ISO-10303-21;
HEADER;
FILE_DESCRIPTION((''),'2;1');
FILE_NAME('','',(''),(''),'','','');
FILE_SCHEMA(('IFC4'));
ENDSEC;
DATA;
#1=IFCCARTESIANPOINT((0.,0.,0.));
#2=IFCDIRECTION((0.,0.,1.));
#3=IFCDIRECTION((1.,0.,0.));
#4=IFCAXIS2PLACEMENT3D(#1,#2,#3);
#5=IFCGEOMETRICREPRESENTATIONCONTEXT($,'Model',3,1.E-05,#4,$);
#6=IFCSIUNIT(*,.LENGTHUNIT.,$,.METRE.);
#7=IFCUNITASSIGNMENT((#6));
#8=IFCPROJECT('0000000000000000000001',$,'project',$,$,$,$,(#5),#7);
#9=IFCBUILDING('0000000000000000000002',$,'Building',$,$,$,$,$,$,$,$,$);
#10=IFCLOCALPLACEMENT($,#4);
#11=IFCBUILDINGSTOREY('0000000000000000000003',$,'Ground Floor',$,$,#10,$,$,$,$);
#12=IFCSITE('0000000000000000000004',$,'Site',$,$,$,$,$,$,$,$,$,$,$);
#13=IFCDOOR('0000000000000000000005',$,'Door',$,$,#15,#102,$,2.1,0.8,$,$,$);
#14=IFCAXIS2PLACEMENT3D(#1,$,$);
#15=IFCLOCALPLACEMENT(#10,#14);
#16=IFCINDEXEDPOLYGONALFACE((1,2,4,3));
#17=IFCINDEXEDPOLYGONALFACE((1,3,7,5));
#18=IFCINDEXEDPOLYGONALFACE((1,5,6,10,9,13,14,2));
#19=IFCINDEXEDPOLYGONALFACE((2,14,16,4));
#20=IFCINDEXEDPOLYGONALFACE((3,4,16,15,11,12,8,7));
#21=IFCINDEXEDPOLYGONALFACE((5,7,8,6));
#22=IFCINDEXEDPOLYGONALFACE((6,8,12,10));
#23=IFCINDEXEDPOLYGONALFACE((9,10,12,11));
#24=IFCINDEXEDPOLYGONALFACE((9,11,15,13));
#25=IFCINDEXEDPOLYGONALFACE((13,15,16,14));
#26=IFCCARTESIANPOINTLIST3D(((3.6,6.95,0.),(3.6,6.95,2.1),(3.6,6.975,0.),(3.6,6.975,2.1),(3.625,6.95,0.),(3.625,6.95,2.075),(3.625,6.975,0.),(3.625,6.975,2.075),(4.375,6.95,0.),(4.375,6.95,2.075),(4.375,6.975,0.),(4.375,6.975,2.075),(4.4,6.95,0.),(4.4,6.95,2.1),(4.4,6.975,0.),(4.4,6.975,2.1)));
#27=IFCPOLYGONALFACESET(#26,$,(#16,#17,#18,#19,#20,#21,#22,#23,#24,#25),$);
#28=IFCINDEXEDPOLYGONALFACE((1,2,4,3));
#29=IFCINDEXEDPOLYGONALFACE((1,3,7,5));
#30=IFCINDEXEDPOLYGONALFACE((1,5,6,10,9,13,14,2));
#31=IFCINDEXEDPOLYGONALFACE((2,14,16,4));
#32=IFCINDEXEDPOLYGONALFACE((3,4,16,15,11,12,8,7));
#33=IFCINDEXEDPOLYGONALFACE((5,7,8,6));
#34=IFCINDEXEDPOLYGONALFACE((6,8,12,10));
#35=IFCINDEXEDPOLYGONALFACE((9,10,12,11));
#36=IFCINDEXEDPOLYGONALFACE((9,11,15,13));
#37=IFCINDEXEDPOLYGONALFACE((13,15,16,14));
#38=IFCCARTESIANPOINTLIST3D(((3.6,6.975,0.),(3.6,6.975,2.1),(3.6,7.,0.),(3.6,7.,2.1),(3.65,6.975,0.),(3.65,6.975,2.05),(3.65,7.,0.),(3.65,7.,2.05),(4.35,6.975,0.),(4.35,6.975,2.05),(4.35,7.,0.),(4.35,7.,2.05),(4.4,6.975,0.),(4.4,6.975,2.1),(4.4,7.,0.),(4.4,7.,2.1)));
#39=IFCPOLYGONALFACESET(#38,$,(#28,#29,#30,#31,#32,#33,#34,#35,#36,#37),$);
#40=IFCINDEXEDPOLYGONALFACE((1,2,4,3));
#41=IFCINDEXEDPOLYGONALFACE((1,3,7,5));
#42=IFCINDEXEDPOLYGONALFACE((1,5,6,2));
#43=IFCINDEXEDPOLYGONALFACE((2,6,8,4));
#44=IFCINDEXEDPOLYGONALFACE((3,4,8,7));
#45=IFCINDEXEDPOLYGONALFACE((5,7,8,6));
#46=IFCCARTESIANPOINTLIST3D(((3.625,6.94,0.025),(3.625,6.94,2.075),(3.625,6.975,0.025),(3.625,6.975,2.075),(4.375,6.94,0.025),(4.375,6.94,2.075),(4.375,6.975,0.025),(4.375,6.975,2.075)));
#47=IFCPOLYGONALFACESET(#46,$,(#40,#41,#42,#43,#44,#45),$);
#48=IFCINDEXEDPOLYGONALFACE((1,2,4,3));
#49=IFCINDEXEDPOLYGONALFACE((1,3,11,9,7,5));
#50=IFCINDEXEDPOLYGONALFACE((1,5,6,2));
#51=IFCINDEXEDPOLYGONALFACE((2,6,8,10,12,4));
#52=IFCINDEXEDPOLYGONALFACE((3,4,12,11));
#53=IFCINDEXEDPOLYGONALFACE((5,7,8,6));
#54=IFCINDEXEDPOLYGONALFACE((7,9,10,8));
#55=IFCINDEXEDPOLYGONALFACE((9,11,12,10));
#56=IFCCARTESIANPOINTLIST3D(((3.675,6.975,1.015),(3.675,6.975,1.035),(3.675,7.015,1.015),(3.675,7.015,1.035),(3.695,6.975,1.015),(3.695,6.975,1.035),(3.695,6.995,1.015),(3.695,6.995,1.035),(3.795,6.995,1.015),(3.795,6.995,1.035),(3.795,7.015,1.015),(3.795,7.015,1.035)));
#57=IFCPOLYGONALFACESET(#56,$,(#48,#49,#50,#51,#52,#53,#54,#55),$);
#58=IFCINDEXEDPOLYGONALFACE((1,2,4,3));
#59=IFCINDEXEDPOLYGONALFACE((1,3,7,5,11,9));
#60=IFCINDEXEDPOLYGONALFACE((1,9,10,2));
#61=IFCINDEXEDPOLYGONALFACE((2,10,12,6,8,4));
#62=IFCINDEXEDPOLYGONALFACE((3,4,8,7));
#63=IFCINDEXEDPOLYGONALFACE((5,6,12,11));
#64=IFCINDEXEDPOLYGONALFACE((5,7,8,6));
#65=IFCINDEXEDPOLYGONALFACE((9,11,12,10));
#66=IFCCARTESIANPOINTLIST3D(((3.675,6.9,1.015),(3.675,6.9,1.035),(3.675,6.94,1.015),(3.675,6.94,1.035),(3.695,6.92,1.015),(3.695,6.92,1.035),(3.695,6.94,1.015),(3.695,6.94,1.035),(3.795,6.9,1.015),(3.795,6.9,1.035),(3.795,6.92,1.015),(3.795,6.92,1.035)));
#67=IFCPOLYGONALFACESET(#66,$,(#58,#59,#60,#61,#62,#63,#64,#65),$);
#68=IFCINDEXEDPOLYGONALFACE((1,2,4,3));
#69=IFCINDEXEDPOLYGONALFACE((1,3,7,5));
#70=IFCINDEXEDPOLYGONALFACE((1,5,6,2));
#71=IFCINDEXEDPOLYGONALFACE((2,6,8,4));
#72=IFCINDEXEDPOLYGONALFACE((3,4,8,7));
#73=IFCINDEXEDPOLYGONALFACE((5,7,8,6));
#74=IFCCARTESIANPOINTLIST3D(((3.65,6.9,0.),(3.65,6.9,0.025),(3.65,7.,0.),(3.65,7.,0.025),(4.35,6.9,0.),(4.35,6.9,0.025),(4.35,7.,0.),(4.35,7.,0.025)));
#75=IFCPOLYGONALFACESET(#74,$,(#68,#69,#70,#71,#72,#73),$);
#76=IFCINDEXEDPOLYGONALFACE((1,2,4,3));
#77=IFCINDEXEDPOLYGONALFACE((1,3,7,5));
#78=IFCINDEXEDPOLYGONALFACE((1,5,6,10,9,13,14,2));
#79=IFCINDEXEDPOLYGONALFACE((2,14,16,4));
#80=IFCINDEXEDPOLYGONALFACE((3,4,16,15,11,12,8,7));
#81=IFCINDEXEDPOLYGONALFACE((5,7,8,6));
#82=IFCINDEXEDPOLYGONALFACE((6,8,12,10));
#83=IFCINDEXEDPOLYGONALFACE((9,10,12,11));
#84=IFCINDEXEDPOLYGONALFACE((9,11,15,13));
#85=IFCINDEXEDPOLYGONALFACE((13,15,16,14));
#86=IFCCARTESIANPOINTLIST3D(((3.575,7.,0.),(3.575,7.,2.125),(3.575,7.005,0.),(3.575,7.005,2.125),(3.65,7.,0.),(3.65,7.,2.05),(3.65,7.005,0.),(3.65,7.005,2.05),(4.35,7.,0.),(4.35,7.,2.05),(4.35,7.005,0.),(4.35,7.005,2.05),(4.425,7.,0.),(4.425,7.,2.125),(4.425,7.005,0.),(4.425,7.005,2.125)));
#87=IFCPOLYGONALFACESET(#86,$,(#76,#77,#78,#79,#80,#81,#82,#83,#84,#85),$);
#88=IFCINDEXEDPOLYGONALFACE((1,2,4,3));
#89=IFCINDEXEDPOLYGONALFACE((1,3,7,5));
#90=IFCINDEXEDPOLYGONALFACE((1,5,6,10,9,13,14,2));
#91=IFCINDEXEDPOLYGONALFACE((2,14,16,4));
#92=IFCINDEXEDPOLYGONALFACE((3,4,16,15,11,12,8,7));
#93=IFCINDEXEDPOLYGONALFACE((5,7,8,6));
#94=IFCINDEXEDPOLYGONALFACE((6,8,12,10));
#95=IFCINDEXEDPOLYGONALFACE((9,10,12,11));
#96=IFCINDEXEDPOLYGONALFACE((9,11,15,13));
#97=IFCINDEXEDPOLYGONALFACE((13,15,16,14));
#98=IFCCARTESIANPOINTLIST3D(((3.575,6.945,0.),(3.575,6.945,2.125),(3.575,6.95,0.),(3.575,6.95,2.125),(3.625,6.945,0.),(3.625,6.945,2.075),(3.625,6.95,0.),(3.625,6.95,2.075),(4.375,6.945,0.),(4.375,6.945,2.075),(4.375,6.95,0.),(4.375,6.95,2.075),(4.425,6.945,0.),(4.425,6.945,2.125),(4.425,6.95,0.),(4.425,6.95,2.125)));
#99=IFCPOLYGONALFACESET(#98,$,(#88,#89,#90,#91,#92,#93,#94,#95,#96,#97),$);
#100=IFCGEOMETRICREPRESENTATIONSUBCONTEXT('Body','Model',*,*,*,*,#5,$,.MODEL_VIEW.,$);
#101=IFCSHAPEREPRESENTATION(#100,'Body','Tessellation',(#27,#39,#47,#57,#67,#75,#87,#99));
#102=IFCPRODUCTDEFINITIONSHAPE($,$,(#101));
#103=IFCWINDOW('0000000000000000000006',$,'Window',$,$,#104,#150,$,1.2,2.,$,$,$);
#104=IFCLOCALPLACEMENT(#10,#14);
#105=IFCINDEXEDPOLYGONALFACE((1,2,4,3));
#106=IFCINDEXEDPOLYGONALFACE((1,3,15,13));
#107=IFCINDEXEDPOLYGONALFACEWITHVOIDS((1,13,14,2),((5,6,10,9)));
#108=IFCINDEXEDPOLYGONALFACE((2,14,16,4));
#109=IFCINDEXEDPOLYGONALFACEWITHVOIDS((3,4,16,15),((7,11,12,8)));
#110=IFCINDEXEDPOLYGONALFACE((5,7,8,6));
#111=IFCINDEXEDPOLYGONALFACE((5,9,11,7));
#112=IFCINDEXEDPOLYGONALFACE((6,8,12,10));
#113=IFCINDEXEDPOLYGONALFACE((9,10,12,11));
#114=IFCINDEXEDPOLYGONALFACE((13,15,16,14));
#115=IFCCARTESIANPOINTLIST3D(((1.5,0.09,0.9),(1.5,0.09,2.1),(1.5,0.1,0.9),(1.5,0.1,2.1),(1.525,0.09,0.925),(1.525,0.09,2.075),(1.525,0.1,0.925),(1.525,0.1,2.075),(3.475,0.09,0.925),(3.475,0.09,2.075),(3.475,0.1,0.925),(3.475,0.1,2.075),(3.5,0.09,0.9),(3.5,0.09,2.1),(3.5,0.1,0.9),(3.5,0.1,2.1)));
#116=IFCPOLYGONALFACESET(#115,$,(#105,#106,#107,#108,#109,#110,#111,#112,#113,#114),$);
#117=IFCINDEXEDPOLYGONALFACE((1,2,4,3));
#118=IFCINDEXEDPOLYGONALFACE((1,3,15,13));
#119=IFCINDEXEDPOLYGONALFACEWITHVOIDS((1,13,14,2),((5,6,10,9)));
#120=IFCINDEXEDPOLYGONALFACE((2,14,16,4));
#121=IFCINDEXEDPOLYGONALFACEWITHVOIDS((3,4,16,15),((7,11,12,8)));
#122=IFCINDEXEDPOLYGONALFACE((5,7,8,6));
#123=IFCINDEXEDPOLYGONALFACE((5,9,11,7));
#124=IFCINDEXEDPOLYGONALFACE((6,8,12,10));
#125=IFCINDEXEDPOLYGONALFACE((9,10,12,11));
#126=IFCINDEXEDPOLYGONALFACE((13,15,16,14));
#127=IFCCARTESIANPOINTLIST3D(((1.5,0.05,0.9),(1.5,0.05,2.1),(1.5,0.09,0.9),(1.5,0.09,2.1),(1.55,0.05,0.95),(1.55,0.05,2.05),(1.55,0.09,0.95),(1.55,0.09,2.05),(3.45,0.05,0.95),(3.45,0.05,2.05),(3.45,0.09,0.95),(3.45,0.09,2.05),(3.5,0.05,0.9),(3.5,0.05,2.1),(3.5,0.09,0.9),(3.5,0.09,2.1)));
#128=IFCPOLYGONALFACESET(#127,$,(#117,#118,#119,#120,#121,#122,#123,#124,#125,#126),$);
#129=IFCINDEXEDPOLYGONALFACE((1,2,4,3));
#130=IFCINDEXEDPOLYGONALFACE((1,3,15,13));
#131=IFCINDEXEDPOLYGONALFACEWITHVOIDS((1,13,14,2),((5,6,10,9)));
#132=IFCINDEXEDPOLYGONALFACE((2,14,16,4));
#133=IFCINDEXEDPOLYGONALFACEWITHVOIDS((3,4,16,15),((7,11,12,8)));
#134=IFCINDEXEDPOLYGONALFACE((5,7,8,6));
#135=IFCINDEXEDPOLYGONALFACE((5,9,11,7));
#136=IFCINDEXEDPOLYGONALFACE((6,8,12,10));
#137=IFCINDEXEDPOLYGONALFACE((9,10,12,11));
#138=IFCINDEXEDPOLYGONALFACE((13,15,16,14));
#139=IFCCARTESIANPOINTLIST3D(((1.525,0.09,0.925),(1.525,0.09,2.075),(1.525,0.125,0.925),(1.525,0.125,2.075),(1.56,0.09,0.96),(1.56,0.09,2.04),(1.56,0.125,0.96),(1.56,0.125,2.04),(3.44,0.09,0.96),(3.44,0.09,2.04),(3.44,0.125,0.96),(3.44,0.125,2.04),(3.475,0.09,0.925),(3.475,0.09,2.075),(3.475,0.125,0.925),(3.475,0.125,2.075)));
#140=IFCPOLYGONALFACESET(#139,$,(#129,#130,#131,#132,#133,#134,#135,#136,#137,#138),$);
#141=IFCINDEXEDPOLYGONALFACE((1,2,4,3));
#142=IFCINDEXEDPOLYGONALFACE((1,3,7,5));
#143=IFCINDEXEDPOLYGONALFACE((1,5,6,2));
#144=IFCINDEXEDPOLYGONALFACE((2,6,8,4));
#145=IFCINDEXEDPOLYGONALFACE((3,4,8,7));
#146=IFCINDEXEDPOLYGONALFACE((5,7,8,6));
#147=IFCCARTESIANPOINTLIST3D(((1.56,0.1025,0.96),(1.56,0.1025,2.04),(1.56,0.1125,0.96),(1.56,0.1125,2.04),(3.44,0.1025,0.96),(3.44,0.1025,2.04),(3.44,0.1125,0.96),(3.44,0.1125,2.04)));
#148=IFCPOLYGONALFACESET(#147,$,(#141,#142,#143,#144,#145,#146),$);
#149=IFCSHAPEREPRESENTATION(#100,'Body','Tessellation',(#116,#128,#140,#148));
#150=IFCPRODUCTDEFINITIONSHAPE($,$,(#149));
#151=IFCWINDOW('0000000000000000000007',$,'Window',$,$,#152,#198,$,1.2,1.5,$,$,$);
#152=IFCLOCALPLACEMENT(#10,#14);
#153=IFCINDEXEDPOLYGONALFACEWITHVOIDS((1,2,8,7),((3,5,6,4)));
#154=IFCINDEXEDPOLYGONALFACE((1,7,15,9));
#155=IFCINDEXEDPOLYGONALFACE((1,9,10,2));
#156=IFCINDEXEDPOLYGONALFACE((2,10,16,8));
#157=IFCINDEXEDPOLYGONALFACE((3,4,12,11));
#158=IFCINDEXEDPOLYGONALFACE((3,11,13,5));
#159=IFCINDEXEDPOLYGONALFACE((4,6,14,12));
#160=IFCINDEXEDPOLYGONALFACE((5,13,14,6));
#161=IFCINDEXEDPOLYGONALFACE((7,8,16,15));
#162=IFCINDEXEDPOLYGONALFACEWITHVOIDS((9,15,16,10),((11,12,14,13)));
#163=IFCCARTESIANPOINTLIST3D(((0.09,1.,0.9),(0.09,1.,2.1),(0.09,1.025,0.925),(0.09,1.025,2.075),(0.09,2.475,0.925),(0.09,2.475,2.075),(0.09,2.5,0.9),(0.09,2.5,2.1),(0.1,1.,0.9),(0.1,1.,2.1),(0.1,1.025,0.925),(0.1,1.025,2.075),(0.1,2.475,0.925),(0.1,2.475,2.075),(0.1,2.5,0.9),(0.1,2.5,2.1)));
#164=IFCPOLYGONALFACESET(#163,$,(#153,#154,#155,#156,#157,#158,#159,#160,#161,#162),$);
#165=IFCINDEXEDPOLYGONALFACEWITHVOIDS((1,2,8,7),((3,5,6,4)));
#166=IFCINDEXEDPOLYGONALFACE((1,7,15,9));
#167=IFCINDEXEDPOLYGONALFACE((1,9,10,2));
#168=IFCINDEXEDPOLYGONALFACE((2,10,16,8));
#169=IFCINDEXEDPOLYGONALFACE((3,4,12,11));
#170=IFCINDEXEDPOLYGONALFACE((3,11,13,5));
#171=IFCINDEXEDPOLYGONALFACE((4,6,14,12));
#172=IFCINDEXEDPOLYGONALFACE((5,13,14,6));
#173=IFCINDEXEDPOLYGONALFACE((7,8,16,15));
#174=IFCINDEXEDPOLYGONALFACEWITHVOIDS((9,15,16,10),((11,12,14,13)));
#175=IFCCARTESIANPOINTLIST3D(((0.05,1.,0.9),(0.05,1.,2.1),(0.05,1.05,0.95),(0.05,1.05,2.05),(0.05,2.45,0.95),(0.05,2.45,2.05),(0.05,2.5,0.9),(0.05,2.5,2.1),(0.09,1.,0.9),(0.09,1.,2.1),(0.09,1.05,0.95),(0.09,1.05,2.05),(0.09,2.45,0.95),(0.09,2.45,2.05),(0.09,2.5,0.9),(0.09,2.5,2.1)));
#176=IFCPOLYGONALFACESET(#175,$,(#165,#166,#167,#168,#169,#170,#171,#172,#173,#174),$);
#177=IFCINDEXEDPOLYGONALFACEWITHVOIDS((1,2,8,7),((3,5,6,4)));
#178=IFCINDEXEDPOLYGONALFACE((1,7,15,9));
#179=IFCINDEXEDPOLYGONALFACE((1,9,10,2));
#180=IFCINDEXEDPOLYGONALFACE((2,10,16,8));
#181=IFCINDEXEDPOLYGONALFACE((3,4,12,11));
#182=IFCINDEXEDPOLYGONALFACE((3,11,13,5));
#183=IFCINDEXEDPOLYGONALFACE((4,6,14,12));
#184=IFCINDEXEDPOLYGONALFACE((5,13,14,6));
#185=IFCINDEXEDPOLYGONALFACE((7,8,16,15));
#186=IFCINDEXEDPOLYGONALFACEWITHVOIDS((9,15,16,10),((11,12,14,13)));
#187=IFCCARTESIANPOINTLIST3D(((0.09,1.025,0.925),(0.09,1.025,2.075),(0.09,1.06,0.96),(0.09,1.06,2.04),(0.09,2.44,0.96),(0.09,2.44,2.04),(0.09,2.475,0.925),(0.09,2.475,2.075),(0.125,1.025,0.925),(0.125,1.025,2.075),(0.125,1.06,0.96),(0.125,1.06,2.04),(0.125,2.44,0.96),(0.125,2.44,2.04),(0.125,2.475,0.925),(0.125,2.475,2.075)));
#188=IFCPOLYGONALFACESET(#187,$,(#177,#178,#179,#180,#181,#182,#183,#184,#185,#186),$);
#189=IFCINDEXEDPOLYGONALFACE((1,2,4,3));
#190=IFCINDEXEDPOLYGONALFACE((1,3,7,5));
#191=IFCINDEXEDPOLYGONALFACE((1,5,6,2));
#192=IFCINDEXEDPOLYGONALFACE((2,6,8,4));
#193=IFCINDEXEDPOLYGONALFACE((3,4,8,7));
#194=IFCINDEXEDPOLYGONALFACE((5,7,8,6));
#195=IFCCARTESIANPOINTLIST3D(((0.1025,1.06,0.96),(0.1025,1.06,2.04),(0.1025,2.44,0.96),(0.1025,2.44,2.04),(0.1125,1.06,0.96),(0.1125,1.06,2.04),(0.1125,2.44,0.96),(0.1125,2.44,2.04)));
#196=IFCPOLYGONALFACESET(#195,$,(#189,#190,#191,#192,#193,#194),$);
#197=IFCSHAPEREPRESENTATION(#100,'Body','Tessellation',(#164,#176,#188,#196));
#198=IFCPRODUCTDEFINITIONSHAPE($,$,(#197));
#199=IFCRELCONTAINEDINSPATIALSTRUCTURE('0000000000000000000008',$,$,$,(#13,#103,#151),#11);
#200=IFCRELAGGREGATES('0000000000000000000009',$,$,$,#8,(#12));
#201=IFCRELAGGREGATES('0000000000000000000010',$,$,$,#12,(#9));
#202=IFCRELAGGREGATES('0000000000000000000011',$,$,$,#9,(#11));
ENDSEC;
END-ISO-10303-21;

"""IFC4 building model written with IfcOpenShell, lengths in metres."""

from ifc_helpers import new_model, si_unit, frame, origin_with_axes, place, context, subcontext, project, spatial, line, indexed_curve, outline, extrude, element, save


model = new_model("IFC4")

# Units and contexts
model_context = context("Model", 3, precision=1e-05, world=origin_with_axes())
body_context = subcontext(model_context, "Body", "Model", "MODEL_VIEW")
ifc_project = project(units=[si_unit("LENGTHUNIT", "METRE")], contexts=[model_context])

# Site, building, storey
site = spatial("IfcSite", under=ifc_project, Name="Site")
building = spatial("IfcBuilding", under=site, Name="Building")
storey_placement = place(None, origin_with_axes())
storey = spatial("IfcBuildingStorey", under=building, at=storey_placement, Name="Ground Floor")

# Door
door_1_placement = place(storey_placement, frame((4.4, 7.0, 0.0), z_axis=(0.0, 0.0, 1.0), x_axis=(-1.0, 0.0, 0.0)))
element("IfcDoor", 1, at=door_1_placement, inside=storey, Name="Door", OverallHeight=2.1, OverallWidth=0.8, context=body_context, shape_type="SweptSolid", body=[
    extrude(outline(indexed_curve([(0.0, 0.0), (0.0, 2.1), (0.8, 2.1), (0.8, 0.0), (0.775, 0.0), (0.775, 2.075), (0.025, 2.075), (0.025, 0.0)], segments=[line(1, 2, 3, 4, 5, 6, 7, 8, 1)])), frame((0.0, 0.025, 0.0), z_axis=(0.0, -1.0, 0.0), x_axis=(1.0, 0.0, 0.0)), (0.0, 0.0, -1.0), 0.025),
    extrude(outline(indexed_curve([(0.0, 0.0), (0.0, 2.1), (0.8, 2.1), (0.8, 0.0), (0.75, 0.0), (0.75, 2.05), (0.05, 2.05), (0.05, 0.0)], segments=[line(1, 2, 3, 4, 5, 6, 7, 8, 1)])), frame((0.0, 0.0, 0.0), z_axis=(0.0, -1.0, 0.0), x_axis=(1.0, 0.0, 0.0)), (0.0, 0.0, -1.0), 0.025),
    extrude(outline(indexed_curve([(0.0, 0.0), (0.75, 0.0), (0.75, 0.035), (0.0, 0.035)], segments=[line(1, 2, 3, 4, 1)])), frame((0.025, 0.025, 0.025), z_axis=(0.0, 0.0, 1.0), x_axis=(1.0, 0.0, 0.0)), (0.0, 0.0, 1.0), 2.05),
    extrude(outline(indexed_curve([(0.0, 0.0), (0.0, -0.04), (-0.12, -0.04), (-0.12, -0.02), (-0.02, -0.02), (-0.02, 0.0)], segments=[line(1, 2, 3, 4, 5, 6, 1)])), frame((0.725, 0.025, 1.015), z_axis=(0.0, 0.0, 1.0), x_axis=(1.0, 0.0, 0.0)), (0.0, 0.0, 1.0), 0.02),
    extrude(outline(indexed_curve([(0.0, 0.0), (0.0, 0.04), (-0.12, 0.04), (-0.12, 0.02), (-0.02, 0.02), (-0.02, 0.0)], segments=[line(1, 2, 3, 4, 5, 6, 1)])), frame((0.725, 0.06, 1.015), z_axis=(0.0, 0.0, 1.0), x_axis=(1.0, 0.0, 0.0)), (0.0, 0.0, 1.0), 0.02),
    extrude(outline(indexed_curve([(0.0, 0.0), (0.7, 0.0), (0.7, 0.1), (0.0, 0.1)], segments=[line(1, 2, 3, 4, 1)])), frame((0.05, 0.0, 0.0), z_axis=(0.0, 0.0, 1.0), x_axis=(1.0, 0.0, 0.0)), (0.0, 0.0, 1.0), 0.025),
    extrude(outline(indexed_curve([(0.0, 0.0), (0.0, 2.125), (0.85, 2.125), (0.85, 0.0), (0.775, 0.0), (0.775, 2.05), (0.075, 2.05), (0.075, 0.0)], segments=[line(1, 2, 3, 4, 5, 6, 7, 8, 1)])), frame((-0.025, -0.005, 0.0), z_axis=(0.0, -1.0, 0.0), x_axis=(1.0, 0.0, 0.0)), (0.0, 0.0, -1.0), 0.005),
    extrude(outline(indexed_curve([(0.0, 0.0), (0.0, 2.125), (0.85, 2.125), (0.85, 0.0), (0.8, 0.0), (0.8, 2.075), (0.05, 2.075), (0.05, 0.0)], segments=[line(1, 2, 3, 4, 5, 6, 7, 8, 1)])), frame((-0.025, 0.05, 0.0), z_axis=(0.0, -1.0, 0.0), x_axis=(1.0, 0.0, 0.0)), (0.0, 0.0, -1.0), 0.005),
])

# Windows
window_1_placement = place(storey_placement, frame((1.5, 0.0, 0.9), z_axis=(0.0, 0.0, 1.0), x_axis=(1.0, 0.0, 0.0)))
element("IfcWindow", 2, at=window_1_placement, inside=storey, Name="Window", OverallHeight=1.2, OverallWidth=2.0, context=body_context, shape_type="SweptSolid", body=[
    extrude(outline(indexed_curve([(0.0, 0.0), (2.0, 0.0), (2.0, 1.2), (0.0, 1.2)], segments=[line(1, 2, 3, 4, 1)]), holes=[indexed_curve([(0.025, 0.025), (1.975, 0.025), (1.975, 1.175), (0.025, 1.175)], segments=[line(1, 2, 3, 4, 1)])]), frame((0.0, 0.09, 0.0), z_axis=(0.0, -1.0, 0.0), x_axis=(1.0, 0.0, 0.0)), (0.0, 0.0, -1.0), 0.01),
    extrude(outline(indexed_curve([(0.0, 0.0), (2.0, 0.0), (2.0, 1.2), (0.0, 1.2)], segments=[line(1, 2, 3, 4, 1)]), holes=[indexed_curve([(0.05, 0.05), (1.95, 0.05), (1.95, 1.15), (0.05, 1.15)], segments=[line(1, 2, 3, 4, 1)])]), frame((0.0, 0.05, 0.0), z_axis=(0.0, -1.0, 0.0), x_axis=(1.0, 0.0, 0.0)), (0.0, 0.0, -1.0), 0.04),
    extrude(outline(indexed_curve([(0.0, 0.0), (1.95, 0.0), (1.95, 1.15), (0.0, 1.15)], segments=[line(1, 2, 3, 4, 1)]), holes=[indexed_curve([(0.035, 0.035), (1.915, 0.035), (1.915, 1.115), (0.035, 1.115)], segments=[line(1, 2, 3, 4, 1)])]), frame((0.025, 0.09, 0.025), z_axis=(0.0, -1.0, 0.0), x_axis=(1.0, 0.0, 0.0)), (0.0, 0.0, -1.0), 0.035),
    extrude(outline(indexed_curve([(0.035, 0.035), (1.915, 0.035), (1.915, 1.115), (0.035, 1.115)], segments=[line(1, 2, 3, 4, 1)])), frame((0.025, 0.1025, 0.025), z_axis=(0.0, -1.0, 0.0), x_axis=(1.0, 0.0, 0.0)), (0.0, 0.0, -1.0), 0.01),
])
for number, where, z_axis, x_axis, name in (
    (3, (0.0, 2.5, 0.9), (0.0, 0.0, 1.0), (0.0, -1.0, 0.0), "Window"),
):
    element("IfcWindow", number, at=place(storey_placement, frame(where, z_axis=z_axis, x_axis=x_axis)), inside=storey, Name=name, OverallHeight=1.2, OverallWidth=1.5, context=body_context, shape_type="SweptSolid", body=[
        extrude(outline(indexed_curve([(0.0, 0.0), (1.5, 0.0), (1.5, 1.2), (0.0, 1.2)], segments=[line(1, 2, 3, 4, 1)]), holes=[indexed_curve([(0.025, 0.025), (1.475, 0.025), (1.475, 1.175), (0.025, 1.175)], segments=[line(1, 2, 3, 4, 1)])]), frame((0.0, 0.09, 0.0), z_axis=(0.0, -1.0, 0.0), x_axis=(1.0, 0.0, 0.0)), (0.0, 0.0, -1.0), 0.01),
        extrude(outline(indexed_curve([(0.0, 0.0), (1.5, 0.0), (1.5, 1.2), (0.0, 1.2)], segments=[line(1, 2, 3, 4, 1)]), holes=[indexed_curve([(0.05, 0.05), (1.45, 0.05), (1.45, 1.15), (0.05, 1.15)], segments=[line(1, 2, 3, 4, 1)])]), frame((0.0, 0.05, 0.0), z_axis=(0.0, -1.0, 0.0), x_axis=(1.0, 0.0, 0.0)), (0.0, 0.0, -1.0), 0.04),
        extrude(outline(indexed_curve([(0.0, 0.0), (1.45, 0.0), (1.45, 1.15), (0.0, 1.15)], segments=[line(1, 2, 3, 4, 1)]), holes=[indexed_curve([(0.035, 0.035), (1.415, 0.035), (1.415, 1.115), (0.035, 1.115)], segments=[line(1, 2, 3, 4, 1)])]), frame((0.025, 0.09, 0.025), z_axis=(0.0, -1.0, 0.0), x_axis=(1.0, 0.0, 0.0)), (0.0, 0.0, -1.0), 0.035),
        extrude(outline(indexed_curve([(0.035, 0.035), (1.415, 0.035), (1.415, 1.115), (0.035, 1.115)], segments=[line(1, 2, 3, 4, 1)])), frame((0.025, 0.1025, 0.025), z_axis=(0.0, -1.0, 0.0), x_axis=(1.0, 0.0, 0.0)), (0.0, 0.0, -1.0), 0.01),
    ])

save(model, "model.ifc")
